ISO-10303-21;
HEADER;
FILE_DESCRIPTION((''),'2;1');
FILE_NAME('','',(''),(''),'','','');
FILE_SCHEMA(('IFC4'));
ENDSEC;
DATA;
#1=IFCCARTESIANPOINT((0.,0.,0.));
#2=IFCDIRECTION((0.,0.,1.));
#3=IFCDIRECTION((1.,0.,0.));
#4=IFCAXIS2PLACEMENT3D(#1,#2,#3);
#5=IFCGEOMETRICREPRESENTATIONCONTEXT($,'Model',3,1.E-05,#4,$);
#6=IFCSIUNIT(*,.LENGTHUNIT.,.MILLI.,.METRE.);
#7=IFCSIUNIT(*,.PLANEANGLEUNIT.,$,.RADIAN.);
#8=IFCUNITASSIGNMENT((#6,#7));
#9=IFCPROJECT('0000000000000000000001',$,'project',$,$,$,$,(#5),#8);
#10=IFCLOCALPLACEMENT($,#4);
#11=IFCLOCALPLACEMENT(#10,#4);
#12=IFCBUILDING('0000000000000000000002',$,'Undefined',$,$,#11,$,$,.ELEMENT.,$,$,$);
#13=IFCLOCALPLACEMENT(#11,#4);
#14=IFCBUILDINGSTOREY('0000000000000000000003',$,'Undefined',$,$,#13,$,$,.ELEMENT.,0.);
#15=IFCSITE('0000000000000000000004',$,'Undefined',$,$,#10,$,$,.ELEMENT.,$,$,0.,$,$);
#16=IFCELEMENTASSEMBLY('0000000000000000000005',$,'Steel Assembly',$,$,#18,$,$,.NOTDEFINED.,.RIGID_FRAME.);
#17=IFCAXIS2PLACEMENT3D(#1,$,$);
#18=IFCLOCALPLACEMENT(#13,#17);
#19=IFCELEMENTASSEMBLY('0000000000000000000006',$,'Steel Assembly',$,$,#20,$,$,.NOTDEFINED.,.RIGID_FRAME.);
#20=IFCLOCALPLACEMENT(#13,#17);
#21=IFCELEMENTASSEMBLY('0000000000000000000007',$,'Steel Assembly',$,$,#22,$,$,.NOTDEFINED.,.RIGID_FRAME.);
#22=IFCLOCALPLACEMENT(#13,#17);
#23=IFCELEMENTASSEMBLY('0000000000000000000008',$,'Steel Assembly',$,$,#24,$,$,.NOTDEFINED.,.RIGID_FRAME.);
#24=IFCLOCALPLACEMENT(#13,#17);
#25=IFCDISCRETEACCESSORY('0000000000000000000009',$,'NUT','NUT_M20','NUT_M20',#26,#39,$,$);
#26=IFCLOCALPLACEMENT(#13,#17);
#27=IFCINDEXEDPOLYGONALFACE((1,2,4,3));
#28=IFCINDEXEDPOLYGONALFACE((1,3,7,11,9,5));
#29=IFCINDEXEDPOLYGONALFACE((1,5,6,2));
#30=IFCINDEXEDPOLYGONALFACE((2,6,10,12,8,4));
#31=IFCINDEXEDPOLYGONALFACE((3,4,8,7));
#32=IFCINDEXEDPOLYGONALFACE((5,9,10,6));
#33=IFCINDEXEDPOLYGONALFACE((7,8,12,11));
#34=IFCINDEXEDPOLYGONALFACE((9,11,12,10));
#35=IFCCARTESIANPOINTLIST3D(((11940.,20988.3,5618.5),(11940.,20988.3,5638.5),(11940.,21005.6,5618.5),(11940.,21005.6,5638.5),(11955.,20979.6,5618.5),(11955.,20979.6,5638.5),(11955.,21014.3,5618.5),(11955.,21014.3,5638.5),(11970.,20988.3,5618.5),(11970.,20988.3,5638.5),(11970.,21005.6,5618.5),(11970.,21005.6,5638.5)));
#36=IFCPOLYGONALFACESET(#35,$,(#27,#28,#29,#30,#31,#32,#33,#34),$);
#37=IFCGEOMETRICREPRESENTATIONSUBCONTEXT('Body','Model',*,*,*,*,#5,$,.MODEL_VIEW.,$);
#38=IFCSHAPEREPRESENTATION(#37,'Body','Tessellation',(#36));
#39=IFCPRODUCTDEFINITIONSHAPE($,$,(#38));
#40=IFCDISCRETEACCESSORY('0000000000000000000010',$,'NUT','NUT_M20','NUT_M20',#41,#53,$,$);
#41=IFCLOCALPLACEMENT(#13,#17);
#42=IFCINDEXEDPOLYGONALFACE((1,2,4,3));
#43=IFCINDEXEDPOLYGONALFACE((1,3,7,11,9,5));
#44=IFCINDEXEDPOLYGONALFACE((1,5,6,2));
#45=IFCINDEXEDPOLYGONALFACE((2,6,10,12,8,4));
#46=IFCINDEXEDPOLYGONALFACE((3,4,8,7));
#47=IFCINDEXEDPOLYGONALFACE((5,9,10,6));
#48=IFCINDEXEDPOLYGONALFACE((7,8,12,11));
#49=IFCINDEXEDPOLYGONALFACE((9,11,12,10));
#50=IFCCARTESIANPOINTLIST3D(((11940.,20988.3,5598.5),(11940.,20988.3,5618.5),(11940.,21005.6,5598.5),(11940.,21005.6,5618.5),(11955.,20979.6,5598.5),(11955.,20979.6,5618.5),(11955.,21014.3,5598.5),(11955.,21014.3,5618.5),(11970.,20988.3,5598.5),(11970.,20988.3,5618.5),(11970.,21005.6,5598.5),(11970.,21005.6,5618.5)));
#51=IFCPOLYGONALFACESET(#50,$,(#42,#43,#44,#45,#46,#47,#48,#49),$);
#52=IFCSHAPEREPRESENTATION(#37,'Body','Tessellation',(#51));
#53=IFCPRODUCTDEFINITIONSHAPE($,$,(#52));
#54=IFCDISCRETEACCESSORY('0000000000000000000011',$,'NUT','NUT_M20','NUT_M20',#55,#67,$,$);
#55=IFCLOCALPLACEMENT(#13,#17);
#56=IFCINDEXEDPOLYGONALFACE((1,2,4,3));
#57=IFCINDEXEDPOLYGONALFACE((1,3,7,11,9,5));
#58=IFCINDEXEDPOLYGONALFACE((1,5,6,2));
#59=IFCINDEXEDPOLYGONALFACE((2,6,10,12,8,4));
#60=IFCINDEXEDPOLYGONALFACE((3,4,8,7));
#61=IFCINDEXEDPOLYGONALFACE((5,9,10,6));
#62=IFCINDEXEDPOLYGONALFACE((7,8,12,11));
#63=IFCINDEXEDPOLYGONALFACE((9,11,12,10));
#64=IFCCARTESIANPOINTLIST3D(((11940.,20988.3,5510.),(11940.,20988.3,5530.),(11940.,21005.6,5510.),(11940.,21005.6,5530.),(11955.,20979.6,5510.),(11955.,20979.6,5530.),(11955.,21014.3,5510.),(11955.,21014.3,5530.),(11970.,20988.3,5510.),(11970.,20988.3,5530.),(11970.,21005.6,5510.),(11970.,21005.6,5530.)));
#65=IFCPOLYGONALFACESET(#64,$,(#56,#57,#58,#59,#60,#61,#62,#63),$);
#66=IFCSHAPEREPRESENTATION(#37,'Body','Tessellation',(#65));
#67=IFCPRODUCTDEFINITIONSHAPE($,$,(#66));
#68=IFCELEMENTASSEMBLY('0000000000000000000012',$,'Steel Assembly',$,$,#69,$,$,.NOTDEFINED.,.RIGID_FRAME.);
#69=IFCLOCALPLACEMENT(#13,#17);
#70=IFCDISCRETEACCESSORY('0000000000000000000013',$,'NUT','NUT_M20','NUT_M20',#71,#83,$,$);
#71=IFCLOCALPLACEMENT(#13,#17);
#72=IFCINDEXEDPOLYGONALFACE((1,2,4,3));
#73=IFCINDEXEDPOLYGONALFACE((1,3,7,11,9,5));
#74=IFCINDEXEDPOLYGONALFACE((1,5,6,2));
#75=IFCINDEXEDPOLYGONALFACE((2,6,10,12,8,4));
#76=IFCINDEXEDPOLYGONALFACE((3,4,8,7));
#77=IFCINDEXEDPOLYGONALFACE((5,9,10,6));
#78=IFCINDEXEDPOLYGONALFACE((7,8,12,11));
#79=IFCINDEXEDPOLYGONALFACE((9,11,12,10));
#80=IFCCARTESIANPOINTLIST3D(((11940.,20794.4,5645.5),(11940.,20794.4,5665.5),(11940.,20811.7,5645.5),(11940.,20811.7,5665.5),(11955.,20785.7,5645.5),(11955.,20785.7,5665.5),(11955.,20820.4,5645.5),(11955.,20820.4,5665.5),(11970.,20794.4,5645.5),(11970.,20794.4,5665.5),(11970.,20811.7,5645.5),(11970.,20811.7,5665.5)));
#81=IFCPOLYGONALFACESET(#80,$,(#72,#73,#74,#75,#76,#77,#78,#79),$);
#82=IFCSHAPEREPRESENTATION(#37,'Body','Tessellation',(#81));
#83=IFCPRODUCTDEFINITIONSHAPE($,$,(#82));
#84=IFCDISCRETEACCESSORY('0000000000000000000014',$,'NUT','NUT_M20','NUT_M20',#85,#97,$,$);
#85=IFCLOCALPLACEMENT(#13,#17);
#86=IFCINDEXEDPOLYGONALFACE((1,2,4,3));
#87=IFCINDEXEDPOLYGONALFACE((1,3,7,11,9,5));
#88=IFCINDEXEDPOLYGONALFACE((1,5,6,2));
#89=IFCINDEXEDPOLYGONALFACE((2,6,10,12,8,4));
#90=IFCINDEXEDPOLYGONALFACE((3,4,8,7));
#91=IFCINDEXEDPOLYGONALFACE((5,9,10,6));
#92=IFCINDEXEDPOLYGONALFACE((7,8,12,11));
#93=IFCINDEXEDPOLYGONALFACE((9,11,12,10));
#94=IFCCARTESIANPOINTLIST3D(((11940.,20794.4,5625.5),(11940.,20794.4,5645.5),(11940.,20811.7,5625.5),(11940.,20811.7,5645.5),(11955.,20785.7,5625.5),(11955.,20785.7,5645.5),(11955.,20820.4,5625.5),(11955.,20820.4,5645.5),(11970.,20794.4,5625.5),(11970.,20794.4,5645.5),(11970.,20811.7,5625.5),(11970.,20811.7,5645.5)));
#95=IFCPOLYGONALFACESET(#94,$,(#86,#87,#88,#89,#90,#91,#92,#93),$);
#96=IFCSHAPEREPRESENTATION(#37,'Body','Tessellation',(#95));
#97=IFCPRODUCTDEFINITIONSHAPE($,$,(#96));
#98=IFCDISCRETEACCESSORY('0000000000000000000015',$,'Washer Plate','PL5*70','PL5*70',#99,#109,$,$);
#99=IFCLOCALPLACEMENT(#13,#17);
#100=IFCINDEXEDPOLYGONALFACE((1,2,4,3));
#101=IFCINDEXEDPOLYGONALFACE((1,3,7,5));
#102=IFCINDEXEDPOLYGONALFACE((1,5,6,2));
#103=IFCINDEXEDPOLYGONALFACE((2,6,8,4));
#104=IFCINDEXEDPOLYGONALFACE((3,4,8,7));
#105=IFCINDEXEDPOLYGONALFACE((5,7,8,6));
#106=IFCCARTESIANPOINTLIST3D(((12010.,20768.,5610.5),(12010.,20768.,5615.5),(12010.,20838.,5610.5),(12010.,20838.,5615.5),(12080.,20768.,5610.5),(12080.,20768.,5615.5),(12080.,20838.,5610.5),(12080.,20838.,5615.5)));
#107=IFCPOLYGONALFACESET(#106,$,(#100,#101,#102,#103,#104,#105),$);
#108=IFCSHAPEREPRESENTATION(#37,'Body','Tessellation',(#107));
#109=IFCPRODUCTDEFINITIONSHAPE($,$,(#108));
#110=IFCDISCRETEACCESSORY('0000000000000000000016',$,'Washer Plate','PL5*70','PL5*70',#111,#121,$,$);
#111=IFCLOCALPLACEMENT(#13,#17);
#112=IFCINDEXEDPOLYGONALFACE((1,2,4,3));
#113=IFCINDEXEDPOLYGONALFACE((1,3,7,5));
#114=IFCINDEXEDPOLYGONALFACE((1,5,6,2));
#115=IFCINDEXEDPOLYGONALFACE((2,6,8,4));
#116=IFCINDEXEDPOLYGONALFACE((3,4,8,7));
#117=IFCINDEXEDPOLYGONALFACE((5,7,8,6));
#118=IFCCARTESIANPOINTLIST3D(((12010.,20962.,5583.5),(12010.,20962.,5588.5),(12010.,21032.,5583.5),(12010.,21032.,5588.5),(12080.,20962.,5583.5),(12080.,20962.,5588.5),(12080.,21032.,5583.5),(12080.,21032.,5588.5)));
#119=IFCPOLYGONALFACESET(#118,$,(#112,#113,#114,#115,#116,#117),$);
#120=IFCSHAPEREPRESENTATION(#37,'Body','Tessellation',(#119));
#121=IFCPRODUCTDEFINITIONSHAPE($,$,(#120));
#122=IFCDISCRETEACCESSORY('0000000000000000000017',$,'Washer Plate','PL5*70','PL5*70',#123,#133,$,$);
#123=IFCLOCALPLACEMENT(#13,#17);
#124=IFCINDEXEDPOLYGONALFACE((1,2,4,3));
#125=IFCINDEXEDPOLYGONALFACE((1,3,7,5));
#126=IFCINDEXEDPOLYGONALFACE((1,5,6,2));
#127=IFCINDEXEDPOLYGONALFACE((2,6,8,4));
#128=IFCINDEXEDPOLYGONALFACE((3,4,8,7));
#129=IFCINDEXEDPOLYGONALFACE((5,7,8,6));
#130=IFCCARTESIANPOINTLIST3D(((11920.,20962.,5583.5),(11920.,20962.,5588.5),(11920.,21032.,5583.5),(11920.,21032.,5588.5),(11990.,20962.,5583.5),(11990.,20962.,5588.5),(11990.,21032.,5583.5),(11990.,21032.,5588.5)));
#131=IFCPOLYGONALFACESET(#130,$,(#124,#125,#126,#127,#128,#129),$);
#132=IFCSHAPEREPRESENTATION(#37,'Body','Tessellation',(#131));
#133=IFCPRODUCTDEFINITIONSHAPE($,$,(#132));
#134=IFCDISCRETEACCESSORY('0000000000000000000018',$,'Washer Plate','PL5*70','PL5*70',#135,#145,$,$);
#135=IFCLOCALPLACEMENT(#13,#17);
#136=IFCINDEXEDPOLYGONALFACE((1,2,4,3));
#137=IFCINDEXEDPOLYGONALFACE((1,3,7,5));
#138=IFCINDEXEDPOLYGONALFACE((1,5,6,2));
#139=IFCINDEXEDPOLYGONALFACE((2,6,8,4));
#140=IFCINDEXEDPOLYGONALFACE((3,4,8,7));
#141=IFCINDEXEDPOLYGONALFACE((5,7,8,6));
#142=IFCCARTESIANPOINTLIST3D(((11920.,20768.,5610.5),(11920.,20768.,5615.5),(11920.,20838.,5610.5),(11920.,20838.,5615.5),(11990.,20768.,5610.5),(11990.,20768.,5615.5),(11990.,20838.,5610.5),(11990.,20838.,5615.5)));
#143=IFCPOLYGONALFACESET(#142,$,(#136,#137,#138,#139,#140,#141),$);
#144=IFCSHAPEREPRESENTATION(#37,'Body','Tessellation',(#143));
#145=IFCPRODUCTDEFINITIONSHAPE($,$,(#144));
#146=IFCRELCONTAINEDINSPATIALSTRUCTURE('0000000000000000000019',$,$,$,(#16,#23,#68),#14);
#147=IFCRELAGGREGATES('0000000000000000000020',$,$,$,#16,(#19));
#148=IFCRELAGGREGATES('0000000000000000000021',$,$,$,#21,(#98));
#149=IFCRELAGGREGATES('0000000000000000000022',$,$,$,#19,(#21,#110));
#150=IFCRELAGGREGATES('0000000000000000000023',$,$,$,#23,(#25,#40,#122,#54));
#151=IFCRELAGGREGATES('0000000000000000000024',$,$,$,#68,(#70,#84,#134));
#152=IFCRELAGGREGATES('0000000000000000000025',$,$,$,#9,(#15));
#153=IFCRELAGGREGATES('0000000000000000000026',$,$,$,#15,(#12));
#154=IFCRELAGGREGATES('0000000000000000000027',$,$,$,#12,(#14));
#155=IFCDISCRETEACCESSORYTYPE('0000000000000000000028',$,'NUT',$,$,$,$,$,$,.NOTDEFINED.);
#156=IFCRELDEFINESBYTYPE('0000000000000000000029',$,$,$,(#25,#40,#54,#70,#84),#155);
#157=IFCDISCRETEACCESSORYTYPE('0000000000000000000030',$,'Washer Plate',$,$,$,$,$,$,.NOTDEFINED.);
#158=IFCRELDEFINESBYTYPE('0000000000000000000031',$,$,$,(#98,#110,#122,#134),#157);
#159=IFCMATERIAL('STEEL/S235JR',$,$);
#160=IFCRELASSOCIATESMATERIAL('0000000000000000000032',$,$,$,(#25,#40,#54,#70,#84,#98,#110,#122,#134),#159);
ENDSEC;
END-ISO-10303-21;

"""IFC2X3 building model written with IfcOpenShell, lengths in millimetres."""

from ifc_helpers import new_model, si_unit, frame, origin_with_axes, place, context, subcontext, project, spatial, polyline, outline, extrude, material, type_object, element, aggregate, save


model = new_model("IFC2X3")

# Units and contexts
model_context = context("Model", 3, precision=1e-05, world=origin_with_axes())
body_context = subcontext(model_context, "Body", "Model", "MODEL_VIEW")
ifc_project = project(units=[si_unit("LENGTHUNIT", "METRE", prefix="MILLI"), si_unit("PLANEANGLEUNIT", "RADIAN")], contexts=[model_context])

# Site, building, storey
site_placement = place(None, origin_with_axes())
site = spatial("IfcSite", under=ifc_project, at=site_placement, Name="Undefined", CompositionType="ELEMENT", RefElevation=0.0)
building_placement = place(site_placement, origin_with_axes())
building = spatial("IfcBuilding", under=site, at=building_placement, Name="Undefined", CompositionType="ELEMENT")
storey_placement = place(building_placement, origin_with_axes())
storey = spatial("IfcBuildingStorey", under=building, at=storey_placement, Name="Undefined", CompositionType="ELEMENT", Elevation=0.0)

# Shared definitions
ifc_material_1 = material(Name="STEEL/S235JR")

# Element assemblies
assembly_1_placement = place(storey_placement, origin_with_axes())
assembly_1 = element("IfcElementAssembly", 1, at=assembly_1_placement, inside=storey, Name="Steel Assembly", AssemblyPlace="NOTDEFINED", PredefinedType="RIGID_FRAME")
assembly_2_placement = place(assembly_1_placement, origin_with_axes())
assembly_2 = element("IfcElementAssembly", 2, at=assembly_2_placement, Name="Steel Assembly", AssemblyPlace="NOTDEFINED", PredefinedType="RIGID_FRAME")
aggregate(assembly_1, [assembly_2])
assembly_3_placement = place(assembly_2_placement, origin_with_axes())
assembly_3 = element("IfcElementAssembly", 3, at=assembly_3_placement, Name="Steel Assembly", AssemblyPlace="NOTDEFINED", PredefinedType="RIGID_FRAME")
discrete_accessory_type_1 = type_object("IfcDiscreteAccessoryType", Name="NUT")

# Element assemblies, discrete accessories
assembly_4_placement = place(storey_placement, origin_with_axes())
assembly_4 = element("IfcElementAssembly", 4, at=assembly_4_placement, inside=storey, Name="Steel Assembly", AssemblyPlace="NOTDEFINED", PredefinedType="RIGID_FRAME")
discrete_accessory_1_placement = place(assembly_4_placement, frame((11955.0, 20997.0, 5638.5), z_axis=(-1.0, 0.0, 0.0), x_axis=(0.0, 0.0, -1.0)))
discrete_accessory_1 = element("IfcDiscreteAccessory", 5, at=discrete_accessory_1_placement, type_object=discrete_accessory_type_1, material=ifc_material_1, Name="NUT", Description="NUT_M20", ObjectType="NUT_M20", context=body_context, shape_type="SweptSolid", body=[
    extrude(outline(polyline([(8.7, 15.0), (17.3, 0.0), (8.7, -15.0), (-8.7, -15.0), (-17.3, 0.0), (-8.7, 15.0), (8.7, 15.0)])), frame((20.0, 0.0, 0.0), z_axis=(-1.0, 0.0, 0.0), x_axis=(0.0, -1.0, 0.0)), (0.0, 0.0, 1.0), 20.0),
])
discrete_accessory_2_placement = place(assembly_4_placement, frame((11955.0, 20997.0, 5618.5), z_axis=(-1.0, 0.0, 0.0), x_axis=(0.0, 0.0, -1.0)))
discrete_accessory_2 = element("IfcDiscreteAccessory", 6, at=discrete_accessory_2_placement, type_object=discrete_accessory_type_1, material=ifc_material_1, Name="NUT", Description="NUT_M20", ObjectType="NUT_M20", context=body_context, shape_type="SweptSolid", body=[
    extrude(outline(polyline([(8.7, 15.0), (17.3, 0.0), (8.7, -15.0), (-8.7, -15.0), (-17.3, 0.0), (-8.7, 15.0), (8.7, 15.0)])), frame((20.0, 0.0, 0.0), z_axis=(-1.0, 0.0, 0.0), x_axis=(0.0, -1.0, 0.0)), (0.0, 0.0, 1.0), 20.0),
])
discrete_accessory_3_placement = place(assembly_4_placement, frame((11955.0, 20997.0, 5530.0), z_axis=(-1.0, 0.0, 0.0), x_axis=(0.0, 0.0, -1.0)))
discrete_accessory_3 = element("IfcDiscreteAccessory", 7, at=discrete_accessory_3_placement, type_object=discrete_accessory_type_1, material=ifc_material_1, Name="NUT", Description="NUT_M20", ObjectType="NUT_M20", context=body_context, shape_type="SweptSolid", body=[
    extrude(outline(polyline([(8.7, 15.0), (17.3, 0.0), (8.7, -15.0), (-8.7, -15.0), (-17.3, 0.0), (-8.7, 15.0), (8.7, 15.0)])), frame((20.0, 0.0, 0.0), z_axis=(-1.0, 0.0, 0.0), x_axis=(0.0, -1.0, 0.0)), (0.0, 0.0, 1.0), 20.0),
])
assembly_5_placement = place(storey_placement, origin_with_axes())
assembly_5 = element("IfcElementAssembly", 8, at=assembly_5_placement, inside=storey, Name="Steel Assembly", AssemblyPlace="NOTDEFINED", PredefinedType="RIGID_FRAME")
discrete_accessory_4_placement = place(assembly_5_placement, frame((11955.0, 20803.0, 5665.5), z_axis=(-1.0, 0.0, 0.0), x_axis=(0.0, 0.0, -1.0)))
discrete_accessory_4 = element("IfcDiscreteAccessory", 9, at=discrete_accessory_4_placement, type_object=discrete_accessory_type_1, material=ifc_material_1, Name="NUT", Description="NUT_M20", ObjectType="NUT_M20", context=body_context, shape_type="SweptSolid", body=[
    extrude(outline(polyline([(8.7, 15.0), (17.3, 0.0), (8.7, -15.0), (-8.7, -15.0), (-17.3, 0.0), (-8.7, 15.0), (8.7, 15.0)])), frame((20.0, 0.0, 0.0), z_axis=(-1.0, 0.0, 0.0), x_axis=(0.0, -1.0, 0.0)), (0.0, 0.0, 1.0), 20.0),
])
discrete_accessory_5_placement = place(assembly_5_placement, frame((11955.0, 20803.0, 5645.5), z_axis=(-1.0, 0.0, 0.0), x_axis=(0.0, 0.0, -1.0)))
discrete_accessory_5 = element("IfcDiscreteAccessory", 10, at=discrete_accessory_5_placement, type_object=discrete_accessory_type_1, material=ifc_material_1, Name="NUT", Description="NUT_M20", ObjectType="NUT_M20", context=body_context, shape_type="SweptSolid", body=[
    extrude(outline(polyline([(8.7, 15.0), (17.3, 0.0), (8.7, -15.0), (-8.7, -15.0), (-17.3, 0.0), (-8.7, 15.0), (8.7, 15.0)])), frame((20.0, 0.0, 0.0), z_axis=(-1.0, 0.0, 0.0), x_axis=(0.0, -1.0, 0.0)), (0.0, 0.0, 1.0), 20.0),
])

# Discrete accessories
discrete_accessory_type_2 = type_object("IfcDiscreteAccessoryType", Name="Washer Plate")
discrete_accessory_6_placement = place(assembly_3_placement, frame((12080.0, 20768.0, 5613.0), z_axis=(0.0, 0.0, 1.0), x_axis=(0.0, 1.0, 0.0)))
discrete_accessory_6 = element("IfcDiscreteAccessory", 11, at=discrete_accessory_6_placement, type_object=discrete_accessory_type_2, material=ifc_material_1, Name="Washer Plate", Description="PL5*70", ObjectType="PL5*70", context=body_context, shape_type="SweptSolid", body=[
    extrude(outline(polyline([(0.0, 0.0), (70.0, 0.0), (70.0, 70.0), (0.0, 70.0), (0.0, 0.0)])), frame((0.0, 0.0, -2.5), z_axis=(0.0, 0.0, 1.0), x_axis=(1.0, 0.0, 0.0)), (0.0, 0.0, 1.0), 5.0),
])
discrete_accessory_7_placement = place(assembly_2_placement, frame((12080.0, 21032.0, 5586.0), z_axis=(0.0, 0.0, -1.0), x_axis=(0.0, -1.0, 0.0)))
discrete_accessory_7 = element("IfcDiscreteAccessory", 12, at=discrete_accessory_7_placement, type_object=discrete_accessory_type_2, material=ifc_material_1, Name="Washer Plate", Description="PL5*70", ObjectType="PL5*70", context=body_context, shape_type="SweptSolid", body=[
    extrude(outline(polyline([(0.0, 0.0), (70.0, 0.0), (70.0, 70.0), (0.0, 70.0), (0.0, 0.0)])), frame((0.0, 0.0, -2.5), z_axis=(0.0, 0.0, 1.0), x_axis=(1.0, 0.0, 0.0)), (0.0, 0.0, 1.0), 5.0),
])
discrete_accessory_8_placement = place(assembly_4_placement, frame((11990.0, 21032.0, 5586.0), z_axis=(0.0, 0.0, -1.0), x_axis=(0.0, -1.0, 0.0)))
discrete_accessory_8 = element("IfcDiscreteAccessory", 13, at=discrete_accessory_8_placement, type_object=discrete_accessory_type_2, material=ifc_material_1, Name="Washer Plate", Description="PL5*70", ObjectType="PL5*70", context=body_context, shape_type="SweptSolid", body=[
    extrude(outline(polyline([(0.0, 0.0), (70.0, 0.0), (70.0, 70.0), (0.0, 70.0), (0.0, 0.0)])), frame((0.0, 0.0, -2.5), z_axis=(0.0, 0.0, 1.0), x_axis=(1.0, 0.0, 0.0)), (0.0, 0.0, 1.0), 5.0),
])
discrete_accessory_9_placement = place(assembly_5_placement, frame((11990.0, 20768.0, 5613.0), z_axis=(0.0, 0.0, 1.0), x_axis=(0.0, 1.0, 0.0)))
discrete_accessory_9 = element("IfcDiscreteAccessory", 14, at=discrete_accessory_9_placement, type_object=discrete_accessory_type_2, material=ifc_material_1, Name="Washer Plate", Description="PL5*70", ObjectType="PL5*70", context=body_context, shape_type="SweptSolid", body=[
    extrude(outline(polyline([(0.0, 0.0), (70.0, 0.0), (70.0, 70.0), (0.0, 70.0), (0.0, 0.0)])), frame((0.0, 0.0, -2.5), z_axis=(0.0, 0.0, 1.0), x_axis=(1.0, 0.0, 0.0)), (0.0, 0.0, 1.0), 5.0),
])
aggregate(assembly_3, [discrete_accessory_6])
aggregate(assembly_2, [assembly_3, discrete_accessory_7])
aggregate(assembly_4, [discrete_accessory_1, discrete_accessory_2, discrete_accessory_8, discrete_accessory_3])
aggregate(assembly_5, [discrete_accessory_4, discrete_accessory_5, discrete_accessory_9])

save(model, "model.ifc")
